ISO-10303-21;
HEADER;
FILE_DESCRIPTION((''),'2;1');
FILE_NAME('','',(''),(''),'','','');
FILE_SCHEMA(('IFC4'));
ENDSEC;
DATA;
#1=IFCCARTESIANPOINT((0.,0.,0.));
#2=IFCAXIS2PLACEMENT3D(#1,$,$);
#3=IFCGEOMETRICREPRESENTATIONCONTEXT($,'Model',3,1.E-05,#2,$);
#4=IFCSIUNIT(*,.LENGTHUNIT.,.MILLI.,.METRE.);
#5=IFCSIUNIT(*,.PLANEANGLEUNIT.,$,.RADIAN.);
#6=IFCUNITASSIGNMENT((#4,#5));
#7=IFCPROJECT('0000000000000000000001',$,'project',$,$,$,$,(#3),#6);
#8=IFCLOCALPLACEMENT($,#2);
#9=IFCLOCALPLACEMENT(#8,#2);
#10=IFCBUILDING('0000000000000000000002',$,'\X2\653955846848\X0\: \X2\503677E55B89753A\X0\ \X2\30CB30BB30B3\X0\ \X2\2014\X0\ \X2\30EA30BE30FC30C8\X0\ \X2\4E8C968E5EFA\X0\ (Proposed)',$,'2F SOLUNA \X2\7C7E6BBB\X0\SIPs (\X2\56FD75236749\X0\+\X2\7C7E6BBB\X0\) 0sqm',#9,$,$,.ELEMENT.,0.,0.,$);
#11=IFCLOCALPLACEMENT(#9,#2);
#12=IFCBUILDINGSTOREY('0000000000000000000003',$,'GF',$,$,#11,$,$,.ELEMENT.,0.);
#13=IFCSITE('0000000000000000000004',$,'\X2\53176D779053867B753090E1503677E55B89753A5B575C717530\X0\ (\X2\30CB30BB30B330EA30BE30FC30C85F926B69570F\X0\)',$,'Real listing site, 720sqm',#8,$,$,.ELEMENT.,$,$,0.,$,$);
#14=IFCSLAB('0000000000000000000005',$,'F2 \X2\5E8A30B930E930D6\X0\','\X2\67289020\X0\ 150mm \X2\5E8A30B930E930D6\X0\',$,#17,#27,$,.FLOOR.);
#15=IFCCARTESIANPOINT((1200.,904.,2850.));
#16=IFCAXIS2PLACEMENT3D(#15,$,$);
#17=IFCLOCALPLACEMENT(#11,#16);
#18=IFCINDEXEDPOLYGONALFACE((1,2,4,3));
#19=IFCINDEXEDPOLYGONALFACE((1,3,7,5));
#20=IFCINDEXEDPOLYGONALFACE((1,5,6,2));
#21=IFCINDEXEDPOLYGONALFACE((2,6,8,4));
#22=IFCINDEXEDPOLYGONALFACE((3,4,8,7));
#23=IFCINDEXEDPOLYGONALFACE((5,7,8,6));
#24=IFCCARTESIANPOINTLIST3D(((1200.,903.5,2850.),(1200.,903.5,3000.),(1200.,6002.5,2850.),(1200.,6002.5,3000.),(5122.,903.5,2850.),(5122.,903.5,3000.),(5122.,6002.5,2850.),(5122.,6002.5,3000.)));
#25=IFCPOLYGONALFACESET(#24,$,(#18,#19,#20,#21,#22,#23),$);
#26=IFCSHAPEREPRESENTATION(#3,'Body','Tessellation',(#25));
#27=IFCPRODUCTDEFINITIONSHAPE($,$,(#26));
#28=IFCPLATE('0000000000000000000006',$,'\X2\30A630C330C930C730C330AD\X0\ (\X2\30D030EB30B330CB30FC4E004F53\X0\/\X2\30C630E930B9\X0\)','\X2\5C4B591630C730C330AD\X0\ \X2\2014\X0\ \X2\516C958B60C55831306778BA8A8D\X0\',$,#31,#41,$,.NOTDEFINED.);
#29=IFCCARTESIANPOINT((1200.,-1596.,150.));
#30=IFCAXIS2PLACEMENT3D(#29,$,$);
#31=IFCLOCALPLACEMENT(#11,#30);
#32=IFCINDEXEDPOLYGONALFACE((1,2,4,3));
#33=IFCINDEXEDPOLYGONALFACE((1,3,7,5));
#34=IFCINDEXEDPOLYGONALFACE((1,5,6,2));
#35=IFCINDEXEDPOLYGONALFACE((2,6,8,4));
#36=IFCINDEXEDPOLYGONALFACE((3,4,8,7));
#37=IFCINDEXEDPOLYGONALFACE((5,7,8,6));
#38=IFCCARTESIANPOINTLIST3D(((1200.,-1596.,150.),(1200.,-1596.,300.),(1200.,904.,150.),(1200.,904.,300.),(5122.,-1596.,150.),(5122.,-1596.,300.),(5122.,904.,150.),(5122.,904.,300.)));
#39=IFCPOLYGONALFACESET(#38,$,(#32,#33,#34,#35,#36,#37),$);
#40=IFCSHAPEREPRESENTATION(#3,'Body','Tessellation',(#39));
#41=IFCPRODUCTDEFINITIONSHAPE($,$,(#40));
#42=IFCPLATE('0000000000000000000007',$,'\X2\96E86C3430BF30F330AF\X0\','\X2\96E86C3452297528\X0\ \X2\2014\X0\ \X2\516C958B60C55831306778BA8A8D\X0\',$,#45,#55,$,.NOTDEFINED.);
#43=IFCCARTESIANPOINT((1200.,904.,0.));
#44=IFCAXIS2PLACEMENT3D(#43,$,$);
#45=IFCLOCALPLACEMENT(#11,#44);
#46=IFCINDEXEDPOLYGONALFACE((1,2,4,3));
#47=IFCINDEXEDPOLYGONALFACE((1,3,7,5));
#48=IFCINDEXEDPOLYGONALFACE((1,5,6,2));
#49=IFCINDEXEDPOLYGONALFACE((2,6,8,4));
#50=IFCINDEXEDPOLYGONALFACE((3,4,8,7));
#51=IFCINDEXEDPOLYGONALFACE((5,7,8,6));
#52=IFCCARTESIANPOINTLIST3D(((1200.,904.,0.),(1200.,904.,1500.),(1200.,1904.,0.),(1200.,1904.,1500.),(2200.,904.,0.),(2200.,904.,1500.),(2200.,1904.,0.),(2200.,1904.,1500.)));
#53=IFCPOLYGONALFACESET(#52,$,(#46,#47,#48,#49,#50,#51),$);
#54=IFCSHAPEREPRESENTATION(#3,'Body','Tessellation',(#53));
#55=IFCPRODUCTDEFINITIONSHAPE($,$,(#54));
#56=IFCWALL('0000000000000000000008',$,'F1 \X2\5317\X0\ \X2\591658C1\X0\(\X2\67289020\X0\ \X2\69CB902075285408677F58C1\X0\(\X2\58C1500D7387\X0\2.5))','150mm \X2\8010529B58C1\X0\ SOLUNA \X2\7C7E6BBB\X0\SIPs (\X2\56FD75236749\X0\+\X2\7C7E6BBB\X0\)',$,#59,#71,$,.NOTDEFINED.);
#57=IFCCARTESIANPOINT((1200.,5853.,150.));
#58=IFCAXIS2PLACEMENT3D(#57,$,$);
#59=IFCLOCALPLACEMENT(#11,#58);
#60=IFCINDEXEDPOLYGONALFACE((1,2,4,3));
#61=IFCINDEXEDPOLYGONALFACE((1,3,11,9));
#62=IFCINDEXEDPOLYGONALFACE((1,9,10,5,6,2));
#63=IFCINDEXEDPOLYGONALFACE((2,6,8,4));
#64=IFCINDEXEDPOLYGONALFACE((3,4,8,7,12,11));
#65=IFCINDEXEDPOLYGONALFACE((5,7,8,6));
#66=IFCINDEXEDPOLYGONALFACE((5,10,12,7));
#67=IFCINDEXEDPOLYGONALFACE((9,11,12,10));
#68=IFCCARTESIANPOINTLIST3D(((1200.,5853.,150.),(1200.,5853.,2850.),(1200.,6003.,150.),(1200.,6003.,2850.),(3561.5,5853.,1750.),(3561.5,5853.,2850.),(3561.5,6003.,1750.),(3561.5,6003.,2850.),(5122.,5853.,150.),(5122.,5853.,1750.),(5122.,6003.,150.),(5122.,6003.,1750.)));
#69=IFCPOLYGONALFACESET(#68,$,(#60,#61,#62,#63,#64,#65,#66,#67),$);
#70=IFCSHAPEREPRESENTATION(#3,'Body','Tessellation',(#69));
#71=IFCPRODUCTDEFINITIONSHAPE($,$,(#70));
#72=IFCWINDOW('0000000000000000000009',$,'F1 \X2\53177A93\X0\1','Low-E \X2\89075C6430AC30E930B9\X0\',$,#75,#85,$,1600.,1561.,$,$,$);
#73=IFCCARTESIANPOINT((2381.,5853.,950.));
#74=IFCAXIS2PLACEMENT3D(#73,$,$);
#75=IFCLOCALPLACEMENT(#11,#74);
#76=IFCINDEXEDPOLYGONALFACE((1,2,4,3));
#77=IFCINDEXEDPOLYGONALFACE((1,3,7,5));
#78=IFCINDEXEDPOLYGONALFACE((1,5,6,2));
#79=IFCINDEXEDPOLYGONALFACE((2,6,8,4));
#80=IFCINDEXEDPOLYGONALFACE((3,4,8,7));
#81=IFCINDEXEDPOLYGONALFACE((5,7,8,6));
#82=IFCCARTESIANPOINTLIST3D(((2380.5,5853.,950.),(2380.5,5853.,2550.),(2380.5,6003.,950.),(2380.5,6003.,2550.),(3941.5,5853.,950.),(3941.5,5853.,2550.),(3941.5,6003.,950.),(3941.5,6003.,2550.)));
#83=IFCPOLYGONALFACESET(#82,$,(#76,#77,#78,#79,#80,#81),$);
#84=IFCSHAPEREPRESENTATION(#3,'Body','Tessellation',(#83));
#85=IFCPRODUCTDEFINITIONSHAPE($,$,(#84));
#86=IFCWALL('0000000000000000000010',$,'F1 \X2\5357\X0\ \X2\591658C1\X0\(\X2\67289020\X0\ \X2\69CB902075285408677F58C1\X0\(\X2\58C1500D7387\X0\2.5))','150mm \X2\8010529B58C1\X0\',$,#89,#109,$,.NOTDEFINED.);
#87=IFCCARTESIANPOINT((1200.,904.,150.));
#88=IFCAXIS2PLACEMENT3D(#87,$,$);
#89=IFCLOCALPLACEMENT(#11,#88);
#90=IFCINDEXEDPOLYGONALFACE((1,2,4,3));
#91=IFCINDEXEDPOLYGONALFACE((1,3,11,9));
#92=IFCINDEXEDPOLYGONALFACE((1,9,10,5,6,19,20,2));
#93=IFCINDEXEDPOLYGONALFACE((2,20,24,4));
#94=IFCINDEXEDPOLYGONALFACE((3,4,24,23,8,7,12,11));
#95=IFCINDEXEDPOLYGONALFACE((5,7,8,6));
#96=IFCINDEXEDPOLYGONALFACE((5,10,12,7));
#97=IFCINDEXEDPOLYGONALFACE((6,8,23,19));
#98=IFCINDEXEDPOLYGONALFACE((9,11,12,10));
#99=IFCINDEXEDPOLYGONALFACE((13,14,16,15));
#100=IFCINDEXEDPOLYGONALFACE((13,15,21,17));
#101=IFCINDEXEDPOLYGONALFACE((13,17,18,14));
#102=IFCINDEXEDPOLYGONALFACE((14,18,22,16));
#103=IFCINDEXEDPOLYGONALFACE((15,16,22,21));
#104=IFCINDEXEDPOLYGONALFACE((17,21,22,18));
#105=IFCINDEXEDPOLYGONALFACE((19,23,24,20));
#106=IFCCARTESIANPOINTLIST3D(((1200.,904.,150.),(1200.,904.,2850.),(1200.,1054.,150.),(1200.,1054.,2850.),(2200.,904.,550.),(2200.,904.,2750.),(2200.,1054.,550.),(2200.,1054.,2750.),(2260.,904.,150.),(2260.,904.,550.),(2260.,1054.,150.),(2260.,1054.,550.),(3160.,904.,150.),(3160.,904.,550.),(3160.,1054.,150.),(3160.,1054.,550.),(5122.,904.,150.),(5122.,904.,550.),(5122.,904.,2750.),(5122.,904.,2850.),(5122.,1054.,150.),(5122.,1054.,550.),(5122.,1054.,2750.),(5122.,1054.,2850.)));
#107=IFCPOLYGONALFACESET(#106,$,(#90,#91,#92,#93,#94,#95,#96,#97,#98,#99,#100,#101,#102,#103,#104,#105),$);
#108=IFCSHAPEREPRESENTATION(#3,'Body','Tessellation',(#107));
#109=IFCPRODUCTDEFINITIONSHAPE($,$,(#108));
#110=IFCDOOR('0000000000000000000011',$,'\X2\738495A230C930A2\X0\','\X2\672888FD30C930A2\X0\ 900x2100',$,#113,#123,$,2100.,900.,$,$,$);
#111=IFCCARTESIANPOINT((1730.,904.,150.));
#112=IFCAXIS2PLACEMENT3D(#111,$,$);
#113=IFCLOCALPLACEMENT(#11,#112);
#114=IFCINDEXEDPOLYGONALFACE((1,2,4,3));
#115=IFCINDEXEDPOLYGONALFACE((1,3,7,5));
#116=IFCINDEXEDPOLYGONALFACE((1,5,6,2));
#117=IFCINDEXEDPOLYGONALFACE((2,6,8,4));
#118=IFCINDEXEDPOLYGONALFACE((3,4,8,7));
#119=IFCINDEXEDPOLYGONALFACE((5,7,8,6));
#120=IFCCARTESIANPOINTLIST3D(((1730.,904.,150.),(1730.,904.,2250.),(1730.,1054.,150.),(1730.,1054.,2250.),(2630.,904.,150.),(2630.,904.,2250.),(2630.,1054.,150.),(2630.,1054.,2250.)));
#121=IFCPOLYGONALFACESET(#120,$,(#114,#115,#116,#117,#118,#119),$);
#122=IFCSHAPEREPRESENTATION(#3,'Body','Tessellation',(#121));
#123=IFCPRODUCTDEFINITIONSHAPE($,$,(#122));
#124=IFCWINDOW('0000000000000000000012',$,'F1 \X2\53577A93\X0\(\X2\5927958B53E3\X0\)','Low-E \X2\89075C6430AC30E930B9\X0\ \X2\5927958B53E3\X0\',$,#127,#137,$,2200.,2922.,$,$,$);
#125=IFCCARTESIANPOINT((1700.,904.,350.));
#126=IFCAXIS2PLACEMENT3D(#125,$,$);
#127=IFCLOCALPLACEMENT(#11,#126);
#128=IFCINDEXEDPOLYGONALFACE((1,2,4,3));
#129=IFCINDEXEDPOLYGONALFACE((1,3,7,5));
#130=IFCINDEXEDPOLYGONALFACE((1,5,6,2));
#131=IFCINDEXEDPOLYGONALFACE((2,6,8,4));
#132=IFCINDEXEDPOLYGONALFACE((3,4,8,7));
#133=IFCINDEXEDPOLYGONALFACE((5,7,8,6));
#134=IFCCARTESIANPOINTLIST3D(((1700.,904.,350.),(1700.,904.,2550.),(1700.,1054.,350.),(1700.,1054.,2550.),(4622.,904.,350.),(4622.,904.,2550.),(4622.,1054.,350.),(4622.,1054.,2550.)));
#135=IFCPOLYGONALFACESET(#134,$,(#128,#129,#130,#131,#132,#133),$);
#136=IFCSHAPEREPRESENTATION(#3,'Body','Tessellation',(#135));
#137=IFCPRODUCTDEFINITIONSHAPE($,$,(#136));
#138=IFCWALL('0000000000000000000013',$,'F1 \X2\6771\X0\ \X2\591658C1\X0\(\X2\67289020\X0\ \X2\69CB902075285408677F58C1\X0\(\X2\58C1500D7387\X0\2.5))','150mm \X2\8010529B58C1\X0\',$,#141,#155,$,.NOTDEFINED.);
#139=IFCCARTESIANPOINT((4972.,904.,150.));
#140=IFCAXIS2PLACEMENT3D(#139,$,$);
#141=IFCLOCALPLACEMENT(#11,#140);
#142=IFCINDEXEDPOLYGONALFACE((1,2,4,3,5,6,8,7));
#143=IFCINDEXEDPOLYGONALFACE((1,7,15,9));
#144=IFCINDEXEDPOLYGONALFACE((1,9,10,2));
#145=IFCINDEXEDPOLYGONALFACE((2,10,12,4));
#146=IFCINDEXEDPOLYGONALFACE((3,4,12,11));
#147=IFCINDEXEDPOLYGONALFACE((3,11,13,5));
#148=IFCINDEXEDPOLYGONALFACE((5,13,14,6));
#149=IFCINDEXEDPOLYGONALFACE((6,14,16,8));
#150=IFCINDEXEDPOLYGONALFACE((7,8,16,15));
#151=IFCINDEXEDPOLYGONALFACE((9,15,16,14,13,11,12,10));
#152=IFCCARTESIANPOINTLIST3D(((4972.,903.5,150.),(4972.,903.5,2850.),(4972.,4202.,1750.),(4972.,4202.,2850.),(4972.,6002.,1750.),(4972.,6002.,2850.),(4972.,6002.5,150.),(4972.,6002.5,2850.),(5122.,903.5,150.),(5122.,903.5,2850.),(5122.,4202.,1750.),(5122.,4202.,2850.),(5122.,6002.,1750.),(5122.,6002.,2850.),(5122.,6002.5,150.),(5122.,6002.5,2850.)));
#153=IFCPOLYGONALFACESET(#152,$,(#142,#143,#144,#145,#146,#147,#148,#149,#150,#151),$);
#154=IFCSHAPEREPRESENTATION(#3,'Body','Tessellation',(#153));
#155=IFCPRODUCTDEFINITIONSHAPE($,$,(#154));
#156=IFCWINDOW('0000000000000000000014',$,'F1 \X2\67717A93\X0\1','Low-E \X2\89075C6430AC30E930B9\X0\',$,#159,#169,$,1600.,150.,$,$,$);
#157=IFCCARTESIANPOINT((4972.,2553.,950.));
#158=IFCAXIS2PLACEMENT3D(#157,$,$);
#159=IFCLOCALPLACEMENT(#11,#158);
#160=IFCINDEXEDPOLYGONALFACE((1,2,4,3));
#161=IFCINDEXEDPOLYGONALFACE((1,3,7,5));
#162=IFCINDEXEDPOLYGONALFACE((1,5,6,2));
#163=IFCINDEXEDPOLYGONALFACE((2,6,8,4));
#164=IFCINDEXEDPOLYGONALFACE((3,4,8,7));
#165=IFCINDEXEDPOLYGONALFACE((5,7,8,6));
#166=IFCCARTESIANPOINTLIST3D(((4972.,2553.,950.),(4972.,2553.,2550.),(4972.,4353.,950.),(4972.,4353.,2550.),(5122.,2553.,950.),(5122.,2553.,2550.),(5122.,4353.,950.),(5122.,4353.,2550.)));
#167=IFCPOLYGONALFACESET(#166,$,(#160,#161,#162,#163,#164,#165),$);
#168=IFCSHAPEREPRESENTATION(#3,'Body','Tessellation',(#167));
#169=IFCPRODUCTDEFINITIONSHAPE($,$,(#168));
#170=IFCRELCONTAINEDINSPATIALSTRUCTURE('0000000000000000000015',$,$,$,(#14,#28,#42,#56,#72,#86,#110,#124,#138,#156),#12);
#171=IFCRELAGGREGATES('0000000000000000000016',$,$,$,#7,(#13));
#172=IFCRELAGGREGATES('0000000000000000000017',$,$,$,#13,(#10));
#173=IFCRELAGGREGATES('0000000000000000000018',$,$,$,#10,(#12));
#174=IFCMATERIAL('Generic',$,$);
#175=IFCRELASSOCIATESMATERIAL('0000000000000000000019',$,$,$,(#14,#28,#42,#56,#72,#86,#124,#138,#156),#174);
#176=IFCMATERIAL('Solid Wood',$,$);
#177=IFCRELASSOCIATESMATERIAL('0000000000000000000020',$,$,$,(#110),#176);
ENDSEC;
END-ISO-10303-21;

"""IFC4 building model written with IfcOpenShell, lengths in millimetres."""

from ifc_helpers import new_model, si_unit, frame, frame_2d, origin, place, context, project, spatial, rectangle, extrude, material, element, fill, save


model = new_model("IFC4")

# Units and contexts
model_context = context("Model", 3, precision=1e-05, world=origin())
ifc_project = project(units=[si_unit("LENGTHUNIT", "METRE", prefix="MILLI"), si_unit("PLANEANGLEUNIT", "RADIAN")], contexts=[model_context])

# Site, building, storey
site_placement = place(None, origin())
site = spatial("IfcSite", under=ifc_project, at=site_placement, Name="北海道虻田郡倶知安町字山田 (ニセコリゾート徒歩圏)", ObjectType="Real listing site, 720sqm", CompositionType="ELEMENT", RefElevation=0.0)
building_placement = place(site_placement, origin())
building = spatial("IfcBuilding", under=site, at=building_placement, Name="改善案: 倶知安町 ニセコ — リゾート 二階建 (Proposed)", ObjectType="2F SOLUNA 籾殻SIPs (国産杉+籾殻) 0sqm", CompositionType="ELEMENT", ElevationOfRefHeight=0.0, ElevationOfTerrain=0.0)
storey_placement = place(building_placement, origin())
storey = spatial("IfcBuildingStorey", under=building, at=storey_placement, Name="GF", CompositionType="ELEMENT", Elevation=0.0)

# Slab
ifc_material_1 = material(Name="Generic")
slab_1_placement = place(storey_placement, frame((1200.0, 904.0, 2850.0)))
element("IfcSlab", 1, at=slab_1_placement, inside=storey, material=ifc_material_1, Name="F2 床スラブ", Description="木造 150mm 床スラブ", PredefinedType="FLOOR", context=model_context, shape_type="SweptSolid", body=[
    extrude(rectangle(XDim=3922.0, YDim=5099.0, at=frame_2d((1961.0, 2549.0))), frame((1200.0, 904.0, 2850.0)), (0.0, 0.0, 1.0), 150.0),
])

# Plates
plate_1_placement = place(storey_placement, frame((1200.0, -1596.0, 150.0)))
element("IfcPlate", 2, at=plate_1_placement, inside=storey, material=ifc_material_1, Name="ウッドデッキ (バルコニー一体/テラス)", Description="屋外デッキ — 公開情報で確認", PredefinedType="NOTDEFINED", context=model_context, shape_type="SweptSolid", body=[
    extrude(rectangle(XDim=3922.0, YDim=2500.0, at=frame_2d((1961.0, 1250.0))), frame((1200.0, -1596.0, 150.0)), (0.0, 0.0, 1.0), 150.0),
])
plate_2_placement = place(storey_placement, frame((1200.0, 904.0, 0.0)))
element("IfcPlate", 3, at=plate_2_placement, inside=storey, material=ifc_material_1, Name="雨水タンク", Description="雨水利用 — 公開情報で確認", PredefinedType="NOTDEFINED", context=model_context, shape_type="SweptSolid", body=[
    extrude(rectangle(XDim=1000.0, YDim=1000.0, at=frame_2d((500.0, 500.0))), frame((1200.0, 904.0, 0.0)), (0.0, 0.0, 1.0), 1500.0),
])

# Wall, opening, window
wall_1_placement = place(storey_placement, frame((1200.0, 5853.0, 150.0)))
wall_1 = element("IfcWall", 4, at=wall_1_placement, inside=storey, material=ifc_material_1, Name="F1 北 外壁(木造 構造用合板壁(壁倍率2.5))", Description="150mm 耐力壁 SOLUNA 籾殻SIPs (国産杉+籾殻)", PredefinedType="NOTDEFINED", context=model_context, shape_type="SweptSolid", body=[
    extrude(rectangle(XDim=3922.0, YDim=150.0, at=frame_2d((1961.0, 75.0))), frame((1200.0, 5853.0, 150.0)), (0.0, 0.0, 1.0), 2700.0),
])
opening_1_placement = place(storey_placement, frame((2381.0, 5853.0, 950.0)))
opening_1 = element("IfcOpeningElement", 5, at=opening_1_placement, cuts=wall_1, PredefinedType="NOTDEFINED", context=model_context, shape_type="SweptSolid", body=[
    extrude(rectangle(XDim=1561.0, YDim=150.0, at=frame_2d((780.0, 75.0))), frame((2381.0, 5853.0, 950.0)), (0.0, 0.0, 1.0), 1600.0),
])
window_1_placement = place(storey_placement, frame((2381.0, 5853.0, 950.0)))
window_1 = element("IfcWindow", 6, at=window_1_placement, inside=storey, material=ifc_material_1, Name="F1 北窓1", Description="Low-E 複層ガラス", OverallHeight=1600.0, OverallWidth=1561.0, context=model_context, shape_type="SweptSolid", body=[
    extrude(rectangle(XDim=1561.0, YDim=150.0, at=frame_2d((780.0, 75.0))), frame((2381.0, 5853.0, 950.0)), (0.0, 0.0, 1.0), 1600.0),
])
fill(opening_1, window_1)

# Wall, openings, door, window
wall_2_placement = place(storey_placement, frame((1200.0, 904.0, 150.0)))
wall_2 = element("IfcWall", 7, at=wall_2_placement, inside=storey, material=ifc_material_1, Name="F1 南 外壁(木造 構造用合板壁(壁倍率2.5))", Description="150mm 耐力壁", PredefinedType="NOTDEFINED", context=model_context, shape_type="SweptSolid", body=[
    extrude(rectangle(XDim=3922.0, YDim=150.0, at=frame_2d((1961.0, 75.0))), frame((1200.0, 904.0, 150.0)), (0.0, 0.0, 1.0), 2700.0),
])
opening_2_placement = place(storey_placement, frame((1730.0, 904.0, 150.0)))
opening_2 = element("IfcOpeningElement", 8, at=opening_2_placement, cuts=wall_2, PredefinedType="NOTDEFINED", context=model_context, shape_type="SweptSolid", body=[
    extrude(rectangle(XDim=900.0, YDim=150.0, at=frame_2d((450.0, 75.0))), frame((1730.0, 904.0, 150.0)), (0.0, 0.0, 1.0), 2100.0),
])
opening_3_placement = place(storey_placement, frame((1700.0, 904.0, 350.0)))
opening_3 = element("IfcOpeningElement", 9, at=opening_3_placement, cuts=wall_2, PredefinedType="NOTDEFINED", context=model_context, shape_type="SweptSolid", body=[
    extrude(rectangle(XDim=2922.0, YDim=150.0, at=frame_2d((1461.0, 75.0))), frame((1700.0, 904.0, 350.0)), (0.0, 0.0, 1.0), 2200.0),
])
ifc_material_2 = material(Name="Solid Wood")
door_placement = place(storey_placement, frame((1730.0, 904.0, 150.0)))
door = element("IfcDoor", 10, at=door_placement, inside=storey, material=ifc_material_2, Name="玄関ドア", Description="木製ドア 900x2100", OverallHeight=2100.0, OverallWidth=900.0, context=model_context, shape_type="SweptSolid", body=[
    extrude(rectangle(XDim=900.0, YDim=150.0, at=frame_2d((450.0, 75.0))), frame((1730.0, 904.0, 150.0)), (0.0, 0.0, 1.0), 2100.0),
])
fill(opening_2, door)
window_2_placement = place(storey_placement, frame((1700.0, 904.0, 350.0)))
window_2 = element("IfcWindow", 11, at=window_2_placement, inside=storey, material=ifc_material_1, Name="F1 南窓(大開口)", Description="Low-E 複層ガラス 大開口", OverallHeight=2200.0, OverallWidth=2922.0, context=model_context, shape_type="SweptSolid", body=[
    extrude(rectangle(XDim=2922.0, YDim=150.0, at=frame_2d((1461.0, 75.0))), frame((1700.0, 904.0, 350.0)), (0.0, 0.0, 1.0), 2200.0),
])
fill(opening_3, window_2)

# Wall, opening, window
wall_3_placement = place(storey_placement, frame((4972.0, 904.0, 150.0)))
wall_3 = element("IfcWall", 12, at=wall_3_placement, inside=storey, material=ifc_material_1, Name="F1 東 外壁(木造 構造用合板壁(壁倍率2.5))", Description="150mm 耐力壁", PredefinedType="NOTDEFINED", context=model_context, shape_type="SweptSolid", body=[
    extrude(rectangle(XDim=150.0, YDim=5099.0, at=frame_2d((75.0, 2549.0))), frame((4972.0, 904.0, 150.0)), (0.0, 0.0, 1.0), 2700.0),
])
opening_4_placement = place(storey_placement, frame((4972.0, 2553.0, 950.0)))
opening_4 = element("IfcOpeningElement", 13, at=opening_4_placement, cuts=wall_3, PredefinedType="NOTDEFINED", context=model_context, shape_type="SweptSolid", body=[
    extrude(rectangle(XDim=150.0, YDim=1800.0, at=frame_2d((75.0, 900.0))), frame((4972.0, 2553.0, 950.0)), (0.0, 0.0, 1.0), 1600.0),
])
window_3_placement = place(storey_placement, frame((4972.0, 2553.0, 950.0)))
window_3 = element("IfcWindow", 14, at=window_3_placement, inside=storey, material=ifc_material_1, Name="F1 東窓1", Description="Low-E 複層ガラス", OverallHeight=1600.0, OverallWidth=150.0, context=model_context, shape_type="SweptSolid", body=[
    extrude(rectangle(XDim=150.0, YDim=1800.0, at=frame_2d((75.0, 900.0))), frame((4972.0, 2553.0, 950.0)), (0.0, 0.0, 1.0), 1600.0),
])
fill(opening_4, window_3)

save(model, "model.ifc")
